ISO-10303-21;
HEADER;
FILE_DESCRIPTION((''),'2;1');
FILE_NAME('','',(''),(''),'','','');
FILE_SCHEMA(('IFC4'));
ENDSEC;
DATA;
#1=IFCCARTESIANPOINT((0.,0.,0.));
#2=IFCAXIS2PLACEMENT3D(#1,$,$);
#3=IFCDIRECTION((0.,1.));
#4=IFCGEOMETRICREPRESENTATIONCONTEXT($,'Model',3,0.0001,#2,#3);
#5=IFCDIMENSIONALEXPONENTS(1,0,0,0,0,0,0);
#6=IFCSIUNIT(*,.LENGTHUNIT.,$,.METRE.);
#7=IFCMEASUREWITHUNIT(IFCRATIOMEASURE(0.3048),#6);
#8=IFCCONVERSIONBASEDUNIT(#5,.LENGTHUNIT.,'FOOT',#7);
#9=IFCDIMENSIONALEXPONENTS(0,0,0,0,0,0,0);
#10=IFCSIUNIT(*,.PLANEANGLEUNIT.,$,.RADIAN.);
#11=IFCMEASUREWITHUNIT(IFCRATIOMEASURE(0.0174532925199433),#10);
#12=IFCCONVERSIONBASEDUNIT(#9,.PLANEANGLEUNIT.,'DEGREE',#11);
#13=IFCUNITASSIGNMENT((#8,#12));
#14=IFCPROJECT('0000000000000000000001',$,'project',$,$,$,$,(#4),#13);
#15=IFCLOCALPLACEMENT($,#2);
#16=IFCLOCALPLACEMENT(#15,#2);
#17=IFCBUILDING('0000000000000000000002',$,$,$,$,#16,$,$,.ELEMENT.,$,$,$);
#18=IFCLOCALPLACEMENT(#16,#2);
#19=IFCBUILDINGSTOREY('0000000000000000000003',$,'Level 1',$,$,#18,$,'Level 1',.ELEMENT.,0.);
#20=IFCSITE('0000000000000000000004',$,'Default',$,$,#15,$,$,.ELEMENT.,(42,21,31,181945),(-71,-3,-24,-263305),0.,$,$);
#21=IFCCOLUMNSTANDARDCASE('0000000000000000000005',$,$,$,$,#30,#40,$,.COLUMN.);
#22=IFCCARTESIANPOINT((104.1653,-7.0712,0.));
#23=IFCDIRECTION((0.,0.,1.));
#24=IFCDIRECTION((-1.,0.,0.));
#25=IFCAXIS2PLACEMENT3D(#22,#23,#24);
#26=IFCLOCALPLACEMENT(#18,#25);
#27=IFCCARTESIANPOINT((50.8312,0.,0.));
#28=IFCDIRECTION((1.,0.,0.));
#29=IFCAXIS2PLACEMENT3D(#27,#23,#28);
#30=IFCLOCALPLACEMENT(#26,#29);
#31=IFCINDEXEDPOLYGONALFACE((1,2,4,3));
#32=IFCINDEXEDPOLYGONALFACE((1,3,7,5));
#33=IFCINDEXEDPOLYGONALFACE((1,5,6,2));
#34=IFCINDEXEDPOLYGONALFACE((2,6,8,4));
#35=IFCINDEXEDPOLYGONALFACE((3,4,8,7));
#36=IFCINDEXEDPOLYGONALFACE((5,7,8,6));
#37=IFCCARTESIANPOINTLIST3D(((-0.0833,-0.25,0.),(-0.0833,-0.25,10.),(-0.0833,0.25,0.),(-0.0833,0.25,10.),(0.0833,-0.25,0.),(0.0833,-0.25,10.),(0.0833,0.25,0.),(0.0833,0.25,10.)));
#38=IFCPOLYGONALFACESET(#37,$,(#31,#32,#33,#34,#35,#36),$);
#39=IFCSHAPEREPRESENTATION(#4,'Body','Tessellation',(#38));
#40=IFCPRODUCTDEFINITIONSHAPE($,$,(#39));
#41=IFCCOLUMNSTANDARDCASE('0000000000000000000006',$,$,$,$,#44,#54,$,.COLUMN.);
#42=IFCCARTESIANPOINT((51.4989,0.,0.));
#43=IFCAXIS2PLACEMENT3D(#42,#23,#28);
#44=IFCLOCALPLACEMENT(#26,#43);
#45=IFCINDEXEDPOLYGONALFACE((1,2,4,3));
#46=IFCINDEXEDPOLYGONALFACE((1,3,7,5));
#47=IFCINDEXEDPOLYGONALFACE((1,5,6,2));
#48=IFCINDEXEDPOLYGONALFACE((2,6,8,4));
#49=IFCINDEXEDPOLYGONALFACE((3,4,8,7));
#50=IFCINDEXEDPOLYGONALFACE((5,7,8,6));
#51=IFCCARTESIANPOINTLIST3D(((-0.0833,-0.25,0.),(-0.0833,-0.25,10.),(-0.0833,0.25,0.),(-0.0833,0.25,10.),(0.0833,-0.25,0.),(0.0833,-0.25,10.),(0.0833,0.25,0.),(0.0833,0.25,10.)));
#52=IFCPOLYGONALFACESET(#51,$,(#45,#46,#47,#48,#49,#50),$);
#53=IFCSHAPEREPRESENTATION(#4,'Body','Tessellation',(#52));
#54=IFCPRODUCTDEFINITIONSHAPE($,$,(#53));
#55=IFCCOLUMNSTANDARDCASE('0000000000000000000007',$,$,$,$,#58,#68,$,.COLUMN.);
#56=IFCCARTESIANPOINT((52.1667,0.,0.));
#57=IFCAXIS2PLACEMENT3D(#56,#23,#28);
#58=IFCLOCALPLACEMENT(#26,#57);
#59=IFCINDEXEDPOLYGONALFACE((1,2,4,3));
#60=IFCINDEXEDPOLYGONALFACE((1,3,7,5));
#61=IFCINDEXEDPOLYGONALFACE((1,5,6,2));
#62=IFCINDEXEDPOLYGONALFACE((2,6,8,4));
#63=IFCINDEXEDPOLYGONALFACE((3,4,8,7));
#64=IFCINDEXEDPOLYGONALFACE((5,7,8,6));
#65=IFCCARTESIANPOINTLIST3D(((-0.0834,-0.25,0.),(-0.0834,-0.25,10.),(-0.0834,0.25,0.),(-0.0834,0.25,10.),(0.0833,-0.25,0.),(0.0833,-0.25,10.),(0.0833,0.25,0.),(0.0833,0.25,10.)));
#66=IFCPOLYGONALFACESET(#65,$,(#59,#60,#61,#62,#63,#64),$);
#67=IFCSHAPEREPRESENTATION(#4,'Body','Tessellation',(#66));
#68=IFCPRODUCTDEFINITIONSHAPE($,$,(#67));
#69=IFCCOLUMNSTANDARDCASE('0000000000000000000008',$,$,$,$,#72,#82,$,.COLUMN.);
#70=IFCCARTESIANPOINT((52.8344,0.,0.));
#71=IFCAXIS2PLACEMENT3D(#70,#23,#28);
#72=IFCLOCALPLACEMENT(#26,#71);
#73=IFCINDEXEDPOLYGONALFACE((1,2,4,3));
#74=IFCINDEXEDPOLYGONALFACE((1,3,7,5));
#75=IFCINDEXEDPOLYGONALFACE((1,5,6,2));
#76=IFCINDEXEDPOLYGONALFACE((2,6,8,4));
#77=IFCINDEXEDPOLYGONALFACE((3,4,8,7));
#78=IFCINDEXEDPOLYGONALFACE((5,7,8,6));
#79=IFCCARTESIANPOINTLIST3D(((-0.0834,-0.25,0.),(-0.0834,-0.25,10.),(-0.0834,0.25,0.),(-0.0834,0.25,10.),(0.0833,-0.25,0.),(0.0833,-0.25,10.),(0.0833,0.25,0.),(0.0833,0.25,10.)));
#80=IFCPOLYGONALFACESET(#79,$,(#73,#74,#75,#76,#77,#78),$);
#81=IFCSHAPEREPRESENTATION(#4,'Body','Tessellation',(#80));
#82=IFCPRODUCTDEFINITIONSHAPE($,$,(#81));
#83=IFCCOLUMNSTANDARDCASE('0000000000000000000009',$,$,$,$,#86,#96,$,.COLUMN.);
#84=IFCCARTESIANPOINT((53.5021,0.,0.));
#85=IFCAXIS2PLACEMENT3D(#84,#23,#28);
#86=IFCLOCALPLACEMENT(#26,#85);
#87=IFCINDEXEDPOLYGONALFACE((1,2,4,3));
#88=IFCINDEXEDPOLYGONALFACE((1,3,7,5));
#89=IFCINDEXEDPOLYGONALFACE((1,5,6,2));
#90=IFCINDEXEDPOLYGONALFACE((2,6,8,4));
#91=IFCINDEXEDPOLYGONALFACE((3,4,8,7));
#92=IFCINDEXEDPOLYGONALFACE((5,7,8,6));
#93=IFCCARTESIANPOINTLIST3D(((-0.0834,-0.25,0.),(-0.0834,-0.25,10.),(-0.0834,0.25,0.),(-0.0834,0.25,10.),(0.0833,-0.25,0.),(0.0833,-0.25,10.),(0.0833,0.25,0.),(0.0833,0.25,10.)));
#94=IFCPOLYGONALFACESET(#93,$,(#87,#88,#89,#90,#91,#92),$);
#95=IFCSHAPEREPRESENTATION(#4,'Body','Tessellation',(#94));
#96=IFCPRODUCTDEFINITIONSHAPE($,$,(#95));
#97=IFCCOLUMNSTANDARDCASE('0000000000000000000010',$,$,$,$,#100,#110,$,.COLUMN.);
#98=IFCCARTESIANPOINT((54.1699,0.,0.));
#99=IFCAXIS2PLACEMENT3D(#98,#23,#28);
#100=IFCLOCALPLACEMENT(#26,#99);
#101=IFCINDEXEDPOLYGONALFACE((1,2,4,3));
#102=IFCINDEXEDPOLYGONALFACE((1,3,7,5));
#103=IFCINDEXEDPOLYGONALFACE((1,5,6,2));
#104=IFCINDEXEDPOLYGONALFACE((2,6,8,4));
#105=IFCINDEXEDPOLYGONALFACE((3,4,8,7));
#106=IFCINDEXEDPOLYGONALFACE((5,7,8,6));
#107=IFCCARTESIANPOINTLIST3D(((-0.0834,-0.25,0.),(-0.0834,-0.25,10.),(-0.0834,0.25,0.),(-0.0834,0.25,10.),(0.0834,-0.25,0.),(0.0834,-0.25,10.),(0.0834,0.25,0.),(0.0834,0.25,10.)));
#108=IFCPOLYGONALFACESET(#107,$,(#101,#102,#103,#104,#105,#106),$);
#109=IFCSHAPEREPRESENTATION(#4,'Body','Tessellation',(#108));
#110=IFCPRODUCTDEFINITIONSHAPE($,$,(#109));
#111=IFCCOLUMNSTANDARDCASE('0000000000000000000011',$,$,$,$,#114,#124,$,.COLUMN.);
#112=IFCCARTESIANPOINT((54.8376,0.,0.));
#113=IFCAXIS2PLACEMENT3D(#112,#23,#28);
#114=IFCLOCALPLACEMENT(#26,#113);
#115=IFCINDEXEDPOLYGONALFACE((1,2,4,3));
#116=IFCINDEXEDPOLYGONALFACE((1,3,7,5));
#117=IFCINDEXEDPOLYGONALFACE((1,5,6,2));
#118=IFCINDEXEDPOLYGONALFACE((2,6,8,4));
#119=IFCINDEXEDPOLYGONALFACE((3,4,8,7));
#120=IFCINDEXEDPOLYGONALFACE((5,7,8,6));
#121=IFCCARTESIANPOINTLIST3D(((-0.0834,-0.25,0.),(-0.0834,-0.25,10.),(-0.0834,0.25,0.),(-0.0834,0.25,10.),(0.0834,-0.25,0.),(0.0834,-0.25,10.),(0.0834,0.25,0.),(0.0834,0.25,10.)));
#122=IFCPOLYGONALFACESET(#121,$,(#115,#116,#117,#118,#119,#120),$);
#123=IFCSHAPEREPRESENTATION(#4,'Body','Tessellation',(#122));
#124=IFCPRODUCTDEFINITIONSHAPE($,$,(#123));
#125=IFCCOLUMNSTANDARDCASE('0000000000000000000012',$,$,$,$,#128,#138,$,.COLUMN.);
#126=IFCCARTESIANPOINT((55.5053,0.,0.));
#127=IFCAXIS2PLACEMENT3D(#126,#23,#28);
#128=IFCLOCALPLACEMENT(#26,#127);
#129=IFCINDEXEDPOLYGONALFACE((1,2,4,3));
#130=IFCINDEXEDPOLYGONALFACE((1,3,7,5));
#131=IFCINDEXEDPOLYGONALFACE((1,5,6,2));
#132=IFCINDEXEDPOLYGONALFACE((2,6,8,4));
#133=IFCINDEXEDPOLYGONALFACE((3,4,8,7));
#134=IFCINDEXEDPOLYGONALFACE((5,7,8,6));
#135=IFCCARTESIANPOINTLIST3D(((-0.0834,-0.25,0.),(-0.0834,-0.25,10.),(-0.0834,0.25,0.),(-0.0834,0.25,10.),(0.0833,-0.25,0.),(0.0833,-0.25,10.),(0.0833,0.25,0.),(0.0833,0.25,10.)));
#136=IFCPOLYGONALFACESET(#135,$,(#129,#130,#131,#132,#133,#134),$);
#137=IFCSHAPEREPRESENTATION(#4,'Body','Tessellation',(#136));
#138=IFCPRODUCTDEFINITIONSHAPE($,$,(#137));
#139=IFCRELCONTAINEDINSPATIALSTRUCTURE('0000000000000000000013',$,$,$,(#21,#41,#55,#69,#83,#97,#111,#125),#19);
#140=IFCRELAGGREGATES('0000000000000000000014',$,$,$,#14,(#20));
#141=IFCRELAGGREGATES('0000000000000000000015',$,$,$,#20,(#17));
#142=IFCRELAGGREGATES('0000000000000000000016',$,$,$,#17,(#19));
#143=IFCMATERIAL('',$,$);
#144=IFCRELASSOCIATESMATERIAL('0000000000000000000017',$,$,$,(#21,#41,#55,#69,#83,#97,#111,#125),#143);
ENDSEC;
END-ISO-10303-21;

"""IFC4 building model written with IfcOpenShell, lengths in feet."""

from ifc_helpers import new_model, entity, si_unit, converted_unit, direction, frame, origin, place, context, project, spatial, rectangle, extrude, material, element, save


model = new_model("IFC4")

# Units and contexts
model_context = context("Model", 3, precision=0.0001, world=origin(), true_north=direction((0.0, 1.0)))
ifc_project = project(units=[converted_unit("LENGTHUNIT", "FOOT", entity("IfcRatioMeasure", 0.3048), si_unit("LENGTHUNIT", "METRE"), dimensions=[1, 0, 0, 0, 0, 0, 0]), converted_unit("PLANEANGLEUNIT", "DEGREE", entity("IfcRatioMeasure", 0.0174532925199433), si_unit("PLANEANGLEUNIT", "RADIAN"), dimensions=[0, 0, 0, 0, 0, 0, 0])], contexts=[model_context])

# Site, building, storey
site_placement = place(None, origin())
site = spatial("IfcSite", under=ifc_project, at=site_placement, Name="Default", CompositionType="ELEMENT", RefLatitude=(42, 21, 31, 181945), RefLongitude=(-71, -3, -24, -263305), RefElevation=0.0)
building_placement = place(site_placement, origin())
building = spatial("IfcBuilding", under=site, at=building_placement, CompositionType="ELEMENT")
storey_placement = place(building_placement, origin())
storey = spatial("IfcBuildingStorey", under=building, at=storey_placement, Name="Level 1", LongName="Level 1", CompositionType="ELEMENT", Elevation=0.0)

# Columns
ifc_material_1 = material(Name="")
placement_1 = place(storey_placement, frame((104.1653, -7.0712, 0.0), z_axis=(0.0, 0.0, 1.0), x_axis=(-1.0, 0.0, 0.0)))
for number, where, z_axis, x_axis in (
    (1, (50.8312, 0.0, 0.0), (0.0, 0.0, 1.0), (1.0, 0.0, 0.0)),
    (2, (51.4989, 0.0, 0.0), (0.0, 0.0, 1.0), (1.0, 0.0, 0.0)),
    (3, (52.1667, 0.0, 0.0), (0.0, 0.0, 1.0), (1.0, 0.0, 0.0)),
    (4, (52.8344, 0.0, 0.0), (0.0, 0.0, 1.0), (1.0, 0.0, 0.0)),
    (5, (53.5021, 0.0, 0.0), (0.0, 0.0, 1.0), (1.0, 0.0, 0.0)),
    (6, (54.1699, 0.0, 0.0), (0.0, 0.0, 1.0), (1.0, 0.0, 0.0)),
    (7, (54.8376, 0.0, 0.0), (0.0, 0.0, 1.0), (1.0, 0.0, 0.0)),
    (8, (55.5053, 0.0, 0.0), (0.0, 0.0, 1.0), (1.0, 0.0, 0.0)),
):
    element("IfcColumnStandardCase", number, at=place(placement_1, frame(where, z_axis=z_axis, x_axis=x_axis)), inside=storey, material=ifc_material_1, PredefinedType="COLUMN", context=model_context, shape_type="SweptSolid", body=[
        extrude(rectangle(XDim=0.1667, YDim=0.5), origin(), (0.0, 0.0, 1.0), 10.0),
    ])

save(model, "model.ifc")
